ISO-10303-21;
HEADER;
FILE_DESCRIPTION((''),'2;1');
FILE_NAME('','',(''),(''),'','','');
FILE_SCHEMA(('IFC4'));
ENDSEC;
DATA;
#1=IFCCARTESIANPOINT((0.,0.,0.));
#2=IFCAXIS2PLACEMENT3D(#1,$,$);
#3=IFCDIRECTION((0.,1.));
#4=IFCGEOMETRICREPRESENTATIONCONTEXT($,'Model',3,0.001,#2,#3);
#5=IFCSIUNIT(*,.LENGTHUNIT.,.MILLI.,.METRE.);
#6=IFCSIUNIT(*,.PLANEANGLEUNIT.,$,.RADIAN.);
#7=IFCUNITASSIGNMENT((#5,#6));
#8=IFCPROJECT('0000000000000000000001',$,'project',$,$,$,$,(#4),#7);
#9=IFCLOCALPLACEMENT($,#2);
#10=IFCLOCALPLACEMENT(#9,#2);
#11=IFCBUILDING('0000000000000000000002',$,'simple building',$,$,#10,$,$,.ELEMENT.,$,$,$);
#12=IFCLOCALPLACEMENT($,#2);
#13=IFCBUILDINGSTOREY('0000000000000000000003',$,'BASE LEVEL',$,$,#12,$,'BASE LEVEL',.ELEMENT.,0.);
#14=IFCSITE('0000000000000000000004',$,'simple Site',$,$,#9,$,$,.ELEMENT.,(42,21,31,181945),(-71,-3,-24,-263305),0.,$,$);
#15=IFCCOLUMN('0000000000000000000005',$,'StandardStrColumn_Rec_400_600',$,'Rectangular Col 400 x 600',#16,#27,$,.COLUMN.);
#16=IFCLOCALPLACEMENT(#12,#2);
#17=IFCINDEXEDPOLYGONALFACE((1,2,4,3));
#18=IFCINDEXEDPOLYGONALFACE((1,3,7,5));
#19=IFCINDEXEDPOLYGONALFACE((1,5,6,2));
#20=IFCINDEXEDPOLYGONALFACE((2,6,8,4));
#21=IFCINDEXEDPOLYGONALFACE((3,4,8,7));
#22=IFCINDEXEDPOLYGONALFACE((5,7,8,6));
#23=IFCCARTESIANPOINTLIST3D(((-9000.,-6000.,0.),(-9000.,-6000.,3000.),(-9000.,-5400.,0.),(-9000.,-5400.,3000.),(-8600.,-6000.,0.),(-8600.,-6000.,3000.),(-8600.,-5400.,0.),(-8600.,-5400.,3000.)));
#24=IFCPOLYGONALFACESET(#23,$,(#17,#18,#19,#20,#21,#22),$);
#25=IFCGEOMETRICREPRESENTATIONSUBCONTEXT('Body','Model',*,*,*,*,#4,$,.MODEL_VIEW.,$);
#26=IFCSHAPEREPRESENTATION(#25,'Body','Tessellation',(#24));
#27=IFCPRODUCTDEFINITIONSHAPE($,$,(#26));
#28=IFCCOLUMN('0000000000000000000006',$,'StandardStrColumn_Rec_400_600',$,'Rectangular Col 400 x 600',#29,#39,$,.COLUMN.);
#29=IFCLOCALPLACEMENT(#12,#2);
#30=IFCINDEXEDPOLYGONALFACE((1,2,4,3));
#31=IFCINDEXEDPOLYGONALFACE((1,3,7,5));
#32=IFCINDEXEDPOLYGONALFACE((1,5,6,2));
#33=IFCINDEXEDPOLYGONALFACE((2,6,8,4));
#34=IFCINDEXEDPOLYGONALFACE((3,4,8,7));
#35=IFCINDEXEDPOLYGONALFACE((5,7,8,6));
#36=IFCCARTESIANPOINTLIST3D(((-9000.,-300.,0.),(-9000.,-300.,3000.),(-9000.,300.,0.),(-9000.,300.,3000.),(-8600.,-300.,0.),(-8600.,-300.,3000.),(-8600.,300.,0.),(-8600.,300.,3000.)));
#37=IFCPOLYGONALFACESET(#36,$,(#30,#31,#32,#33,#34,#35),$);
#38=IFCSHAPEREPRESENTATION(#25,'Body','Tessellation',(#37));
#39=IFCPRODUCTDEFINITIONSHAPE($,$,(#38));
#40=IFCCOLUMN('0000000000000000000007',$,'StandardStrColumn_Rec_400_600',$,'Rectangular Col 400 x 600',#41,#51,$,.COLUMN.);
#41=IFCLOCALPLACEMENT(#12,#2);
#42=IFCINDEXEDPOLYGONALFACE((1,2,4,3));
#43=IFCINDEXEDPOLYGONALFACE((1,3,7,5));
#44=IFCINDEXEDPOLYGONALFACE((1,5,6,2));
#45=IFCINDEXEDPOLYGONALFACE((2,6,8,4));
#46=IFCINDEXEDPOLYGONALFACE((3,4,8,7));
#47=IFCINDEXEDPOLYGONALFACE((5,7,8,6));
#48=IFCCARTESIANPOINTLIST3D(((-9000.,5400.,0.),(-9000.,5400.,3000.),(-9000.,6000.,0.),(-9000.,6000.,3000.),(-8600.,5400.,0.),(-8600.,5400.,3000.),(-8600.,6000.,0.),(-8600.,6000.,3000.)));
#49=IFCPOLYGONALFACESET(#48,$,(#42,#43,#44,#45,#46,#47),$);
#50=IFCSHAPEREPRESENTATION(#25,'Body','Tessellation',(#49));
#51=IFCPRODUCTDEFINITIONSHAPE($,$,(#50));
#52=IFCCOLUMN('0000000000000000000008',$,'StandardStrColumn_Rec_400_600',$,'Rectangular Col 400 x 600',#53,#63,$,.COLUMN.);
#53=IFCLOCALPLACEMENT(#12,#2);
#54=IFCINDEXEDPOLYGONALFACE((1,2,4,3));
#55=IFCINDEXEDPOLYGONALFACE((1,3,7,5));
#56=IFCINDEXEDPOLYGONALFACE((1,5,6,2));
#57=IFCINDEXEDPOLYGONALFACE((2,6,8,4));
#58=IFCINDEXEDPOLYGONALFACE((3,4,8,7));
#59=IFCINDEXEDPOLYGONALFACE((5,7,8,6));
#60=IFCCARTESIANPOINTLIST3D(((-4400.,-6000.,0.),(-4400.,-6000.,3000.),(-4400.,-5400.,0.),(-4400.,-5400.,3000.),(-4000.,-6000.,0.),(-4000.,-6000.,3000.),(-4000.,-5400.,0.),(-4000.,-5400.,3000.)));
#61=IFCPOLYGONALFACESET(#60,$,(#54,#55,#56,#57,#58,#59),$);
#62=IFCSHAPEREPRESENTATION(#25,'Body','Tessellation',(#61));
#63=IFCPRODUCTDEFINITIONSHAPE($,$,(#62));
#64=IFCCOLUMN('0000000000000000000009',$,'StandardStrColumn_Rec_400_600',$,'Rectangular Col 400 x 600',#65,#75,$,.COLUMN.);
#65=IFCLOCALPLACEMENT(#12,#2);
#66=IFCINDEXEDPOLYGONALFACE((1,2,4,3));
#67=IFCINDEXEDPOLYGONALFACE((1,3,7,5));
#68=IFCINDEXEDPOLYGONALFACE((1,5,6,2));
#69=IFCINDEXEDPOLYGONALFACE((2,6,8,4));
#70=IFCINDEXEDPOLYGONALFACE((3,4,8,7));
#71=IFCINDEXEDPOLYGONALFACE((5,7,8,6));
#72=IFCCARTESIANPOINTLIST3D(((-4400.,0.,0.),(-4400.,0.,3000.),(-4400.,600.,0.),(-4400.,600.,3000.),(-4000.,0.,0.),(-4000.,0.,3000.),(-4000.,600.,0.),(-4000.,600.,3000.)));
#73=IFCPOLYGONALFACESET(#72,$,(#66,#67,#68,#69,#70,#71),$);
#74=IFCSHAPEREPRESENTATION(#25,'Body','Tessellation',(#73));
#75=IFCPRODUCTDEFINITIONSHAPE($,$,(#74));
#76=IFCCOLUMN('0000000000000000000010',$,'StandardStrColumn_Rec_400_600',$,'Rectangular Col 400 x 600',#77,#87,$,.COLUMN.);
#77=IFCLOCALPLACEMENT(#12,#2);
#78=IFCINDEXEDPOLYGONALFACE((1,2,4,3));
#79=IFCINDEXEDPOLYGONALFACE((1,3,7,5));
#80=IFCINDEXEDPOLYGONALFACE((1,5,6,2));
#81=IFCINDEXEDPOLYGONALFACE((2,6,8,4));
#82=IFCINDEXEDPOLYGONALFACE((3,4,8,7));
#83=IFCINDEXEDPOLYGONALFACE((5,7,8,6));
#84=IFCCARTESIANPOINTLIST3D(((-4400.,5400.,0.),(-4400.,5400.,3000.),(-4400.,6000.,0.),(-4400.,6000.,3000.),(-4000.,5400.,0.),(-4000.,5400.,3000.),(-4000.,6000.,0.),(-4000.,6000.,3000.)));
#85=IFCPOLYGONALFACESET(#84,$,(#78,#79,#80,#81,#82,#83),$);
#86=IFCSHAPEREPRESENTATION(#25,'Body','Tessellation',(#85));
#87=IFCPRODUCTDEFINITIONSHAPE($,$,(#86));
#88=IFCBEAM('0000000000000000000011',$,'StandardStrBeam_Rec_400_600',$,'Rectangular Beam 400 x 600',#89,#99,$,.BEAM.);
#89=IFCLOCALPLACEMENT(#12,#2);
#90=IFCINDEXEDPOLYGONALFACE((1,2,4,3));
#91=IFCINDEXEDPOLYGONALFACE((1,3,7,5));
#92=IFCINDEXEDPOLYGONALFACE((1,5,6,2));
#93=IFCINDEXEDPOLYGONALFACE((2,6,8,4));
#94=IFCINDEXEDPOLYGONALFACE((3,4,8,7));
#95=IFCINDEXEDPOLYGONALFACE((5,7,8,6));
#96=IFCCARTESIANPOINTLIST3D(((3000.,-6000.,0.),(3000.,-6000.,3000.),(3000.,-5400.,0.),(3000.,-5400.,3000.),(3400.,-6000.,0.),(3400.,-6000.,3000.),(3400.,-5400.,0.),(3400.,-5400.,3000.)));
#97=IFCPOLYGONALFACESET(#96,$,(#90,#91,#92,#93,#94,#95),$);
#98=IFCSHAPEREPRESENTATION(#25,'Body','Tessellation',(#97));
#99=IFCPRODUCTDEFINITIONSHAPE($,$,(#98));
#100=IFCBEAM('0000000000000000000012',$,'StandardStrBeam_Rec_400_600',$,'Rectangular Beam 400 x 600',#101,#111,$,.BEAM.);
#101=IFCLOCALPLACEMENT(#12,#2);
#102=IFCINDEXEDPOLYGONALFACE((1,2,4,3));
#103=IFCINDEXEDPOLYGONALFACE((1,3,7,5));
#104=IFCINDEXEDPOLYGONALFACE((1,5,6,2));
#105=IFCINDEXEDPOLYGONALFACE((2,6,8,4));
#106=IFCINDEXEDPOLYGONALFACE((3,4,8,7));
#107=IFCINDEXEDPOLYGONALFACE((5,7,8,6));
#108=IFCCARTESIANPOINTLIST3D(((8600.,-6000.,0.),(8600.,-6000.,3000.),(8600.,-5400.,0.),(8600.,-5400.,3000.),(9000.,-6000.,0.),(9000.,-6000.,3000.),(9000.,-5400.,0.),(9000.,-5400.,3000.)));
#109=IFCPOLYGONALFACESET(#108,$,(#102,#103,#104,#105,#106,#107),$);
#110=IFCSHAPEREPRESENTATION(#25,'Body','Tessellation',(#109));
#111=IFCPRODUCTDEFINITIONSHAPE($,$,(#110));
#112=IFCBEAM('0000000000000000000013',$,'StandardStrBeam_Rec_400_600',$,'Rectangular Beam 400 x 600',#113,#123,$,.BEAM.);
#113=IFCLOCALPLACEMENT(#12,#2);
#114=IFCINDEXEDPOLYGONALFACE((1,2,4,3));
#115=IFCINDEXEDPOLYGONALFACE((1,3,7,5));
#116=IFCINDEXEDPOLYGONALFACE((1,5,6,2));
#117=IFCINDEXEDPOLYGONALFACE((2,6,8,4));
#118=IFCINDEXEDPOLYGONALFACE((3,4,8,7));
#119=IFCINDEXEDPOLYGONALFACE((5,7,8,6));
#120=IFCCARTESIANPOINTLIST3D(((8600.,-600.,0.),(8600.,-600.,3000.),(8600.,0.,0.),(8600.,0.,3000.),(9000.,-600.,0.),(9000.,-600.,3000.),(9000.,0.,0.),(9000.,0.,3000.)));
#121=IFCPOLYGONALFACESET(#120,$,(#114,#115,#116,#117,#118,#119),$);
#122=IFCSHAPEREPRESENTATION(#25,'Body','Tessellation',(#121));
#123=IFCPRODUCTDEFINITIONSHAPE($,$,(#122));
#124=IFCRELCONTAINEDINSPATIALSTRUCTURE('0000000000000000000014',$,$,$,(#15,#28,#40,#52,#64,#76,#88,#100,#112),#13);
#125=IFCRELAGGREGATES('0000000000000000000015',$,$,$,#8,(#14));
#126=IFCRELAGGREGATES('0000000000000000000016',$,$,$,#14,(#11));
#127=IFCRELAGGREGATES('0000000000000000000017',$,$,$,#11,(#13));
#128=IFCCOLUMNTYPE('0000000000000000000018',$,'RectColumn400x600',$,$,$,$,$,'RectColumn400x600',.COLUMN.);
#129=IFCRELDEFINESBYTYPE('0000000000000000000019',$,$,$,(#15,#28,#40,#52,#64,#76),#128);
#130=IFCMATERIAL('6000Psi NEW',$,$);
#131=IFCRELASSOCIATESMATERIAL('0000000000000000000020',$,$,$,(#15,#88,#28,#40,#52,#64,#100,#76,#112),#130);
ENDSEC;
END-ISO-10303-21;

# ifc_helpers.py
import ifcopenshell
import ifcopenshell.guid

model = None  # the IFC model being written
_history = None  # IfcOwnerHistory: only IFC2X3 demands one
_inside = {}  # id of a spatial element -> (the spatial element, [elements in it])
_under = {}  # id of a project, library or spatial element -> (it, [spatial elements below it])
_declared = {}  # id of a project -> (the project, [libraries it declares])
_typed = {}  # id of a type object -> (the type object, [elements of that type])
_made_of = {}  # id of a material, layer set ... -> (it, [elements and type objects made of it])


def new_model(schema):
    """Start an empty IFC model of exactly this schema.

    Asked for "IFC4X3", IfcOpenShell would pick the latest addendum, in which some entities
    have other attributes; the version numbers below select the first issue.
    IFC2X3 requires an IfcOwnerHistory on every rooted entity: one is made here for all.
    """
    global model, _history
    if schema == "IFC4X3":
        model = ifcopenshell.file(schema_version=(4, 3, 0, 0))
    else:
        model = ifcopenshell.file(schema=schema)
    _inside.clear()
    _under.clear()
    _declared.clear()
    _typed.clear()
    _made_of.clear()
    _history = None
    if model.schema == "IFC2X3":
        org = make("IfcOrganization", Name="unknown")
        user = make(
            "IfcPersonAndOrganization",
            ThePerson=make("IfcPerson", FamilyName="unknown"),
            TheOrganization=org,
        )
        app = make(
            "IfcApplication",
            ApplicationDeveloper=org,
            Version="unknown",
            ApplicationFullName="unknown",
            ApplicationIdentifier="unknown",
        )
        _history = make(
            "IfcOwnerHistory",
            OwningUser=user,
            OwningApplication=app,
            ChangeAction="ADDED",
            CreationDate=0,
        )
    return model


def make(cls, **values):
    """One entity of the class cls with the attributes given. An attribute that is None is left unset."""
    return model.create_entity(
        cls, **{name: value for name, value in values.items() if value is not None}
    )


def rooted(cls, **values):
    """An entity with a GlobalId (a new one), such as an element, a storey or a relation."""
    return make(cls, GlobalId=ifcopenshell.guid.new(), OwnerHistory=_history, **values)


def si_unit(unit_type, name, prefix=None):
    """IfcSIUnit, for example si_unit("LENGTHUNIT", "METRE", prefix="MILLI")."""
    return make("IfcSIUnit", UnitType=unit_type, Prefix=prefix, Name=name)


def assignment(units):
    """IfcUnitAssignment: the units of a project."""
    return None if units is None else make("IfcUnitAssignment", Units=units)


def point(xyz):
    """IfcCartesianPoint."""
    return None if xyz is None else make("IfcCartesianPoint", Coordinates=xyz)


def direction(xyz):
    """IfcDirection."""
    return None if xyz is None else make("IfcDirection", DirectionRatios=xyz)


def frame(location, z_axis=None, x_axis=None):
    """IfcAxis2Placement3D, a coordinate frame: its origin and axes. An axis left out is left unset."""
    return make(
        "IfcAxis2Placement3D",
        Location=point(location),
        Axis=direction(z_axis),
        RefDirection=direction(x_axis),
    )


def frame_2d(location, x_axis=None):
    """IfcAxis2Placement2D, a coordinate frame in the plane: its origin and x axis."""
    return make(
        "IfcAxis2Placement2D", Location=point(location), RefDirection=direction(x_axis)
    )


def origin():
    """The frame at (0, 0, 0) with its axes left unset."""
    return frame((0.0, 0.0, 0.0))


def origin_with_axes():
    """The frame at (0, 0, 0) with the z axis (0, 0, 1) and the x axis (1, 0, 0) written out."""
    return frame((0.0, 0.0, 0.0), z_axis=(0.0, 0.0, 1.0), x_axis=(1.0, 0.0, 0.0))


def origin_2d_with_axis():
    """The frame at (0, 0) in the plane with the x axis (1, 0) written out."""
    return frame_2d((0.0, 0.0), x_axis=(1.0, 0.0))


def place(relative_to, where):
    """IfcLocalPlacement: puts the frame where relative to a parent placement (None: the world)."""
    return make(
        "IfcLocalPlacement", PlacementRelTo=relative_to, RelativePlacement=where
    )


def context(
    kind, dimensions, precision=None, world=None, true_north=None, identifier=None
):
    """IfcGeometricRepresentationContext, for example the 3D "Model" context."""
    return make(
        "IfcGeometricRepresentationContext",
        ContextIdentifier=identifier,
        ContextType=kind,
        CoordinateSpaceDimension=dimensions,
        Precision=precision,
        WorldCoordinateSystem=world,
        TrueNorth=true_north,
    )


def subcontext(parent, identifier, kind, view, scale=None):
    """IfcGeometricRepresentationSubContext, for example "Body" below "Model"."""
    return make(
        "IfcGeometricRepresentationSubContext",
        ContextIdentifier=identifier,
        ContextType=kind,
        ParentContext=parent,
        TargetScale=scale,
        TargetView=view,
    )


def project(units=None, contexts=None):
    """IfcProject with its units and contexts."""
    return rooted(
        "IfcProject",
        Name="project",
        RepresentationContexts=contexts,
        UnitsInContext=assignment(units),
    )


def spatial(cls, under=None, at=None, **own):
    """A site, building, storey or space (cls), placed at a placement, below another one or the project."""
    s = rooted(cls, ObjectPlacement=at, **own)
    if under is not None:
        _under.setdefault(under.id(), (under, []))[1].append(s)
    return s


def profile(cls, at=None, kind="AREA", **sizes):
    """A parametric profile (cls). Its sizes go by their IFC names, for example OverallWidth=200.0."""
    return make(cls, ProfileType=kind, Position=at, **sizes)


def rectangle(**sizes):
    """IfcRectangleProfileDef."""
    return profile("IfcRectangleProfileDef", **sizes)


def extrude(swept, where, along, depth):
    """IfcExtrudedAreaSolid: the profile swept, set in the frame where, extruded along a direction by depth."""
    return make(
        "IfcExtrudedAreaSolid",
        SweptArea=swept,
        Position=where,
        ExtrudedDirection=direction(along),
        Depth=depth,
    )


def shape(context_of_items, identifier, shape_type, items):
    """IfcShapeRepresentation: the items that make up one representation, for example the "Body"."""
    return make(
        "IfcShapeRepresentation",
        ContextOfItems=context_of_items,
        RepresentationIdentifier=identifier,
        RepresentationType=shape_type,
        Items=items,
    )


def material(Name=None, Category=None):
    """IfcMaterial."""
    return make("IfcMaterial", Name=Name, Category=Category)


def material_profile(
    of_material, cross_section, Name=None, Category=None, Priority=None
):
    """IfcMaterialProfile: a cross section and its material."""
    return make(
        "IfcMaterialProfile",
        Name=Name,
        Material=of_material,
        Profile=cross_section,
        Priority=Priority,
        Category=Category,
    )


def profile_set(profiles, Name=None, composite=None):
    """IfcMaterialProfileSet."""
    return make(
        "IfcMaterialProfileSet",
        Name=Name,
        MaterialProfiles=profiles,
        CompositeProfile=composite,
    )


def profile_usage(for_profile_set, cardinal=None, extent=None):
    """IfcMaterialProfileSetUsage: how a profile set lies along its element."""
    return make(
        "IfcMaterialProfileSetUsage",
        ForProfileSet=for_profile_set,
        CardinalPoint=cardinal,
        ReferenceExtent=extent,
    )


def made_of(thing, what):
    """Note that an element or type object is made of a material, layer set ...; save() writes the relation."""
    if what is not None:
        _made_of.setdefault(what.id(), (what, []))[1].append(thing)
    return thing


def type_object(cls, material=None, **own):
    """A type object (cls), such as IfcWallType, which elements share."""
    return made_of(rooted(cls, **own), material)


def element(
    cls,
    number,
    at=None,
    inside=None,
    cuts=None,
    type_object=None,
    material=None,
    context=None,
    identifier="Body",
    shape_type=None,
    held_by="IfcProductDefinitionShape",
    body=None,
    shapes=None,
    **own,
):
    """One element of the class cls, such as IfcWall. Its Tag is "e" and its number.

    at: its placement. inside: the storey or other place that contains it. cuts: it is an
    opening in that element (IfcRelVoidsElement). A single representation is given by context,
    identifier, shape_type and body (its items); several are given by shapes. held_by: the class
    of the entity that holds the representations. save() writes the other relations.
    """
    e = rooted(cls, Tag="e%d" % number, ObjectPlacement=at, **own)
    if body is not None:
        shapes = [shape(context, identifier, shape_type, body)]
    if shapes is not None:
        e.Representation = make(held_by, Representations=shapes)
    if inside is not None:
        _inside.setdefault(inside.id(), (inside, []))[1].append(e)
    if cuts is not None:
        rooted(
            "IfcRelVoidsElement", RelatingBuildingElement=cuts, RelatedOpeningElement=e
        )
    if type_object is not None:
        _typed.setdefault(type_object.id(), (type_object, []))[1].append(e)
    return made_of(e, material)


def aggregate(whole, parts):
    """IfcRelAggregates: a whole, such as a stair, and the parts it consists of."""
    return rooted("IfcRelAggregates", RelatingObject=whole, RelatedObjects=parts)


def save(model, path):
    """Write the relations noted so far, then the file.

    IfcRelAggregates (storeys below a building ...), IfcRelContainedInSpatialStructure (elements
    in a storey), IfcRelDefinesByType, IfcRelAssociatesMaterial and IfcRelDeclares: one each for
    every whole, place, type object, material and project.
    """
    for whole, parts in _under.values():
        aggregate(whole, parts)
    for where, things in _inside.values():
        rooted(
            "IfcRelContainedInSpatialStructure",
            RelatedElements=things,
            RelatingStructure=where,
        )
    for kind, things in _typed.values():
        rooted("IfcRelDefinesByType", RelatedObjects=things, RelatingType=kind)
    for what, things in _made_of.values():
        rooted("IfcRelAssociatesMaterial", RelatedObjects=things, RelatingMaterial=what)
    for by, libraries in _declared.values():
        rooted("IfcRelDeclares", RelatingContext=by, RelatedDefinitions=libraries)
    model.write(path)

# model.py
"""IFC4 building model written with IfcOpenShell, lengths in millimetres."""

from ifc_helpers import new_model, si_unit, direction, frame, origin, origin_with_axes, origin_2d_with_axis, place, context, subcontext, project, spatial, rectangle, extrude, material, material_profile, profile_set, profile_usage, type_object, element, save


model = new_model("IFC4")

# Units and contexts
model_context = context("Model", 3, precision=0.001, world=origin(), true_north=direction((0.0, 1.0)))
body_context = subcontext(model_context, "Body", "Model", "MODEL_VIEW")
ifc_project = project(units=[si_unit("LENGTHUNIT", "METRE", prefix="MILLI"), si_unit("PLANEANGLEUNIT", "RADIAN")], contexts=[model_context])

# Site, building, storey
site_placement = place(None, origin())
site = spatial("IfcSite", under=ifc_project, at=site_placement, Name="simple Site", CompositionType="ELEMENT", RefLatitude=(42, 21, 31, 181945), RefLongitude=(-71, -3, -24, -263305), RefElevation=0.0)
building_placement = place(site_placement, origin())
building = spatial("IfcBuilding", under=site, at=building_placement, Name="simple building", CompositionType="ELEMENT")
storey_placement = place(None, origin())
storey = spatial("IfcBuildingStorey", under=building, at=storey_placement, Name="BASE LEVEL", LongName="BASE LEVEL", CompositionType="ELEMENT", Elevation=0.0)

# Columns
ifc_material = material(Name="6000Psi NEW")
ifc_material_profile = material_profile(ifc_material, rectangle(XDim=400.0, YDim=600.0, at=origin_2d_with_axis()))
ifc_profile_set = profile_set([ifc_material_profile])
ifc_profile_usage_1 = profile_usage(ifc_profile_set, cardinal=7)
column_type = type_object("IfcColumnType", Name="RectColumn400x600", ElementType="RectColumn400x600", PredefinedType="COLUMN")
column_1_placement = place(None, frame((-8800.0, -5700.0, 0.0), z_axis=(0.0, 0.0, 1.0), x_axis=(1.0, 0.0, 0.0)))
element("IfcColumn", 1, at=column_1_placement, inside=storey, type_object=column_type, material=ifc_profile_usage_1, Name="StandardStrColumn_Rec_400_600", ObjectType="Rectangular Col 400 x 600", PredefinedType="COLUMN", context=body_context, shape_type="SweptSolid", body=[
    extrude(rectangle(XDim=400.0, YDim=600.0, at=origin_2d_with_axis()), origin_with_axes(), (0.0, 0.0, 1.0), 3000.0),
])
ifc_profile_usage_2 = profile_usage(ifc_profile_set, cardinal=4)
column_2_placement = place(None, frame((-8800.0, 0.0, 0.0), z_axis=(0.0, 0.0, 1.0), x_axis=(1.0, 0.0, 0.0)))
element("IfcColumn", 2, at=column_2_placement, inside=storey, type_object=column_type, material=ifc_profile_usage_2, Name="StandardStrColumn_Rec_400_600", ObjectType="Rectangular Col 400 x 600", PredefinedType="COLUMN", context=body_context, shape_type="SweptSolid", body=[
    extrude(rectangle(XDim=400.0, YDim=600.0, at=origin_2d_with_axis()), origin_with_axes(), (0.0, 0.0, 1.0), 3000.0),
])
ifc_profile_usage_3 = profile_usage(ifc_profile_set, cardinal=1)
column_3_placement = place(None, frame((-8800.0, 5700.0, 0.0), z_axis=(0.0, 0.0, 1.0), x_axis=(1.0, 0.0, 0.0)))
element("IfcColumn", 3, at=column_3_placement, inside=storey, type_object=column_type, material=ifc_profile_usage_3, Name="StandardStrColumn_Rec_400_600", ObjectType="Rectangular Col 400 x 600", PredefinedType="COLUMN", context=body_context, shape_type="SweptSolid", body=[
    extrude(rectangle(XDim=400.0, YDim=600.0, at=origin_2d_with_axis()), origin_with_axes(), (0.0, 0.0, 1.0), 3000.0),
])
ifc_profile_usage_4 = profile_usage(ifc_profile_set, cardinal=9)
for number, where, z_axis, x_axis, name in (
    (4, (-4200.0, -5700.0, 0.0), (0.0, 0.0, 1.0), (1.0, 0.0, 0.0), "StandardStrColumn_Rec_400_600"),
    (5, (-4200.0, 300.0, 0.0), (0.0, 0.0, 1.0), (1.0, 0.0, 0.0), "StandardStrColumn_Rec_400_600"),
):
    element("IfcColumn", number, at=place(None, frame(where, z_axis=z_axis, x_axis=x_axis)), inside=storey, type_object=column_type, material=ifc_profile_usage_4, Name=name, ObjectType="Rectangular Col 400 x 600", PredefinedType="COLUMN", context=body_context, shape_type="SweptSolid", body=[
        extrude(rectangle(XDim=400.0, YDim=600.0, at=origin_2d_with_axis()), origin_with_axes(), (0.0, 0.0, 1.0), 3000.0),
    ])
ifc_profile_usage_5 = profile_usage(ifc_profile_set, cardinal=3)
column_4_placement = place(None, frame((-4200.0, 5700.0, 0.0), z_axis=(0.0, 0.0, 1.0), x_axis=(1.0, 0.0, 0.0)))
element("IfcColumn", 6, at=column_4_placement, inside=storey, type_object=column_type, material=ifc_profile_usage_5, Name="StandardStrColumn_Rec_400_600", ObjectType="Rectangular Col 400 x 600", PredefinedType="COLUMN", context=body_context, shape_type="SweptSolid", body=[
    extrude(rectangle(XDim=400.0, YDim=600.0, at=origin_2d_with_axis()), origin_with_axes(), (0.0, 0.0, 1.0), 3000.0),
])

# Beams
beam_1_placement = place(None, frame((3200.0, -5700.0, 0.0), z_axis=(0.0, 0.0, 1.0), x_axis=(1.0, 0.0, 0.0)))
element("IfcBeam", 7, at=beam_1_placement, inside=storey, material=ifc_profile_usage_1, Name="StandardStrBeam_Rec_400_600", ObjectType="Rectangular Beam 400 x 600", PredefinedType="BEAM", context=body_context, shape_type="SweptSolid", body=[
    extrude(rectangle(XDim=400.0, YDim=600.0, at=origin_2d_with_axis()), origin_with_axes(), (0.0, 0.0, 1.0), 3000.0),
])
beam_2_placement = place(None, frame((8800.0, -5700.0, 0.0), z_axis=(0.0, 0.0, 1.0), x_axis=(1.0, 0.0, 0.0)))
element("IfcBeam", 8, at=beam_2_placement, inside=storey, material=ifc_profile_usage_4, Name="StandardStrBeam_Rec_400_600", ObjectType="Rectangular Beam 400 x 600", PredefinedType="BEAM", context=body_context, shape_type="SweptSolid", body=[
    extrude(rectangle(XDim=400.0, YDim=600.0, at=origin_2d_with_axis()), origin_with_axes(), (0.0, 0.0, 1.0), 3000.0),
])
beam_3_placement = place(None, frame((8800.0, -300.0, 0.0), z_axis=(0.0, 0.0, 1.0), x_axis=(1.0, 0.0, 0.0)))
element("IfcBeam", 9, at=beam_3_placement, inside=storey, material=ifc_profile_usage_5, Name="StandardStrBeam_Rec_400_600", ObjectType="Rectangular Beam 400 x 600", PredefinedType="BEAM", context=body_context, shape_type="SweptSolid", body=[
    extrude(rectangle(XDim=400.0, YDim=600.0, at=origin_2d_with_axis()), origin_with_axes(), (0.0, 0.0, 1.0), 3000.0),
])

save(model, "model.ifc")
